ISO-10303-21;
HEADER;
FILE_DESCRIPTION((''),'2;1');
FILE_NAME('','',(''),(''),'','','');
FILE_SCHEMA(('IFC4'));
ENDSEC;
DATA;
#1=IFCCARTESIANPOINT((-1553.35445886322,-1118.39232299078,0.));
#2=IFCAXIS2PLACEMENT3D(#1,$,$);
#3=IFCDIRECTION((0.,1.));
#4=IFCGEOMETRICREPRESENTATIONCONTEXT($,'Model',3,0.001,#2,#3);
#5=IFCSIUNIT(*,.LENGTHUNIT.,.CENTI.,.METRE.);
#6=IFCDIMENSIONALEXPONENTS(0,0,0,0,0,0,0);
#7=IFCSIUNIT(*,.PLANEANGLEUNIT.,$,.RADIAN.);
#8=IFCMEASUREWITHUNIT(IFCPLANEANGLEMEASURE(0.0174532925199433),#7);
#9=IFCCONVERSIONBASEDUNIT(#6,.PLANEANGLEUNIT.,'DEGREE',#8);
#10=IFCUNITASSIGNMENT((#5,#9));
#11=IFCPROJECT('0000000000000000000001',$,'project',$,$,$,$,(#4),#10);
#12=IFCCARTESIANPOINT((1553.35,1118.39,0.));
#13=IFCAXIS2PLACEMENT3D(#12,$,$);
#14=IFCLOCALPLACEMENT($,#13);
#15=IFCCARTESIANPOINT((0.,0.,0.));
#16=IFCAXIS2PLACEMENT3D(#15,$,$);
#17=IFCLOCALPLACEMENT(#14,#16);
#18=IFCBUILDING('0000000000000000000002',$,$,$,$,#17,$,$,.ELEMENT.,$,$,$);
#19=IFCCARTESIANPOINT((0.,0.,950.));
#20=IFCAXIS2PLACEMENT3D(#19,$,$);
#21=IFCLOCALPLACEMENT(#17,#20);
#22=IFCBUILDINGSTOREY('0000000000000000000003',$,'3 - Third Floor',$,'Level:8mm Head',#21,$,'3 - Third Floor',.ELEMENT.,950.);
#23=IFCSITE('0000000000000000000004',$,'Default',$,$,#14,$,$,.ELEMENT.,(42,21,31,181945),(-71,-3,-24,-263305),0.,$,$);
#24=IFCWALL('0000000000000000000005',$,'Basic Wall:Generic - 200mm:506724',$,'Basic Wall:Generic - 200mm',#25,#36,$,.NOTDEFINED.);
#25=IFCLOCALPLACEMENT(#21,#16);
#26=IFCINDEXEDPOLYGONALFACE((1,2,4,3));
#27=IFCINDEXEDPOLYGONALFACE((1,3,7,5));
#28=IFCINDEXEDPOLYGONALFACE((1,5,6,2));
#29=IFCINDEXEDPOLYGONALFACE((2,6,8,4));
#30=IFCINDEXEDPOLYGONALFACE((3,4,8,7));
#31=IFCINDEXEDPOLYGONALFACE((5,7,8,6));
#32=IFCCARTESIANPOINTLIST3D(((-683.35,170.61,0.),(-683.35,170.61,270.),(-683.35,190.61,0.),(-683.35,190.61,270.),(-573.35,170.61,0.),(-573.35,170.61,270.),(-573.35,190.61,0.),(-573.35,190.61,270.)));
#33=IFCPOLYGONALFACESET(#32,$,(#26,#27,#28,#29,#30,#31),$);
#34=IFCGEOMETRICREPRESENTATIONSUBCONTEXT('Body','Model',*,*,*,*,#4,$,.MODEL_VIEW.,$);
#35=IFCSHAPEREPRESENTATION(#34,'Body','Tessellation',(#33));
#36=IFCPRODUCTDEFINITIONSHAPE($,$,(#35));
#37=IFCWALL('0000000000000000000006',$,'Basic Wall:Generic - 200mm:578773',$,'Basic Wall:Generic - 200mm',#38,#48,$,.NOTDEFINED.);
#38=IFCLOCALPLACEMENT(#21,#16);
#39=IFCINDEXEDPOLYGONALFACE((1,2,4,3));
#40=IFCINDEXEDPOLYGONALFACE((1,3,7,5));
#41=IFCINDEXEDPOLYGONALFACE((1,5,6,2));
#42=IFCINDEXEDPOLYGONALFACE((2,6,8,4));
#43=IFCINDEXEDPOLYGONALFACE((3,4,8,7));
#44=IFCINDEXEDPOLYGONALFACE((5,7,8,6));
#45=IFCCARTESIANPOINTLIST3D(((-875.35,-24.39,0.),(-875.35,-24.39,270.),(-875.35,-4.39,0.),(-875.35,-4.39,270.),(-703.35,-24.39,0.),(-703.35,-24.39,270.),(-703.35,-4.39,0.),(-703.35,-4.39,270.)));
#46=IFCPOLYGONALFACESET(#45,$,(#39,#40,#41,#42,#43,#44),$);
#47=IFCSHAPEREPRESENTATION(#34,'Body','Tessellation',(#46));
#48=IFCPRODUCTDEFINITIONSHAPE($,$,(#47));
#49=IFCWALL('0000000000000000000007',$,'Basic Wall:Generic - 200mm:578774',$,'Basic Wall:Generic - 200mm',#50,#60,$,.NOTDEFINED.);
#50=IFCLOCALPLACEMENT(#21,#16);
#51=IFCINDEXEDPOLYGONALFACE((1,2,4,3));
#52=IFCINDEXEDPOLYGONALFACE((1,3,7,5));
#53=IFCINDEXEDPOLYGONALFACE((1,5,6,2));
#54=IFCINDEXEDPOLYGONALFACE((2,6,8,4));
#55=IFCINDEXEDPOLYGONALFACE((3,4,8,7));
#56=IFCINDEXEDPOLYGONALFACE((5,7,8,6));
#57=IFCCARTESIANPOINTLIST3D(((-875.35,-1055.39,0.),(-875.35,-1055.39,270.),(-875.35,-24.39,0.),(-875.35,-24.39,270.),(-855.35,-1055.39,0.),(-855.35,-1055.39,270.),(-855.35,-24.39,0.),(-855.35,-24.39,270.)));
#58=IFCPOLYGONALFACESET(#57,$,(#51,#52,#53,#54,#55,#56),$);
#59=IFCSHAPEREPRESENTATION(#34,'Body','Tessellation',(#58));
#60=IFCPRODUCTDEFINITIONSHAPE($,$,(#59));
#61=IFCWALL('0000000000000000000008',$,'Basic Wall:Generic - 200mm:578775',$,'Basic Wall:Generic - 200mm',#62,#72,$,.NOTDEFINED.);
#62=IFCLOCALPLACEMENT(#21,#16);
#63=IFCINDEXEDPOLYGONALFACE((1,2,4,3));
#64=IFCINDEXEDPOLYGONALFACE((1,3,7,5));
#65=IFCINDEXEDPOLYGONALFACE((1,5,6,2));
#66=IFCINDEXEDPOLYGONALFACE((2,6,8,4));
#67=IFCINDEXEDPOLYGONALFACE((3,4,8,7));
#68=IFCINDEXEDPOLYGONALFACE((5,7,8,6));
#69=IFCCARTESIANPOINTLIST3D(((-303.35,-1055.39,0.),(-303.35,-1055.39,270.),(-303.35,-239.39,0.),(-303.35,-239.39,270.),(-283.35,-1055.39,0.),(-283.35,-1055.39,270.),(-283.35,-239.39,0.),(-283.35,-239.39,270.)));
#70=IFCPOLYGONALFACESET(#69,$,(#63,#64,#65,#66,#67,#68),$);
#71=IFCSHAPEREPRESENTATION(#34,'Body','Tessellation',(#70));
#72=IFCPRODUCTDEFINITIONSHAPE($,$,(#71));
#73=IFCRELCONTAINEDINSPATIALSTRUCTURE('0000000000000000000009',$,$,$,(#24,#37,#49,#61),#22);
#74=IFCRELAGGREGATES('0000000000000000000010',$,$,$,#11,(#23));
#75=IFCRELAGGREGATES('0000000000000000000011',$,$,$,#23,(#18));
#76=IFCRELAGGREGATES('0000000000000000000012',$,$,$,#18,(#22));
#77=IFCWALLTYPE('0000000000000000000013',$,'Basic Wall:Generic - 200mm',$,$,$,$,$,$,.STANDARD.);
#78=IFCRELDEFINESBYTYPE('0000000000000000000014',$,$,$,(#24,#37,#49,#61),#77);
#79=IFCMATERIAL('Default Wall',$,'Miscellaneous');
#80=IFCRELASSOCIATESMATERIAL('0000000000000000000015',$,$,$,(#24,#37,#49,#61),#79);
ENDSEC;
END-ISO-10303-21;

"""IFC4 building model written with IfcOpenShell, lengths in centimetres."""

from ifc_helpers import new_model, entity, si_unit, converted_unit, direction, frame, origin, place, context, subcontext, project, spatial, indexed_curve, outline, extrude, material, type_object, element, save


model = new_model("IFC4")

# Units and contexts
model_context = context("Model", 3, precision=0.001, world=frame((-1553.35445886322, -1118.39232299078, 0.0)), true_north=direction((0.0, 1.0)))
body_context = subcontext(model_context, "Body", "Model", "MODEL_VIEW")
ifc_project = project(units=[si_unit("LENGTHUNIT", "METRE", prefix="CENTI"), converted_unit("PLANEANGLEUNIT", "DEGREE", entity("IfcPlaneAngleMeasure", 0.0174532925199433), si_unit("PLANEANGLEUNIT", "RADIAN"), dimensions=[0, 0, 0, 0, 0, 0, 0])], contexts=[model_context])

# Site, building, storey
site_placement = place(None, frame((1553.35, 1118.39, 0.0)))
site = spatial("IfcSite", under=ifc_project, at=site_placement, Name="Default", CompositionType="ELEMENT", RefLatitude=(42, 21, 31, 181945), RefLongitude=(-71, -3, -24, -263305), RefElevation=0.0)
building_placement = place(site_placement, origin())
building = spatial("IfcBuilding", under=site, at=building_placement, CompositionType="ELEMENT")
storey_placement = place(building_placement, frame((0.0, 0.0, 950.0)))
storey = spatial("IfcBuildingStorey", under=building, at=storey_placement, Name="3 - Third Floor", ObjectType="Level:8mm Head", LongName="3 - Third Floor", CompositionType="ELEMENT", Elevation=950.0)

# Walls
ifc_material_1 = material(Name="Default Wall", Category="Miscellaneous")
wall_type_1 = type_object("IfcWallType", Name="Basic Wall:Generic - 200mm", PredefinedType="STANDARD")
wall_1_placement = place(storey_placement, frame((-683.35, 180.61, 0.0)))
element("IfcWall", 1, at=wall_1_placement, inside=storey, type_object=wall_type_1, material=ifc_material_1, Name="Basic Wall:Generic - 200mm:506724", ObjectType="Basic Wall:Generic - 200mm", PredefinedType="NOTDEFINED", context=body_context, shape_type="SweptSolid", body=[
    extrude(outline(indexed_curve([(110.0, 10.0), (0.0, 10.0), (0.0, -10.0), (110.0, -10.0), (110.0, 10.0)], self_intersect=False)), origin(), (0.0, 0.0, 1.0), 270.0),
])
wall_2_placement = place(storey_placement, frame((-703.35, -14.39, 0.0), z_axis=(0.0, 0.0, 1.0), x_axis=(-1.0, 0.0, 0.0)))
element("IfcWall", 2, at=wall_2_placement, inside=storey, type_object=wall_type_1, material=ifc_material_1, Name="Basic Wall:Generic - 200mm:578773", ObjectType="Basic Wall:Generic - 200mm", PredefinedType="NOTDEFINED", context=body_context, shape_type="SweptSolid", body=[
    extrude(outline(indexed_curve([(172.0, 10.0), (0.0, 10.0), (0.0, -10.0), (172.0, -10.0), (172.0, 10.0)], self_intersect=False)), origin(), (0.0, 0.0, 1.0), 270.0),
])
wall_3_placement = place(storey_placement, frame((-865.35, -24.39, 0.0), z_axis=(0.0, 0.0, 1.0), x_axis=(0.0, -1.0, 0.0)))
element("IfcWall", 3, at=wall_3_placement, inside=storey, type_object=wall_type_1, material=ifc_material_1, Name="Basic Wall:Generic - 200mm:578774", ObjectType="Basic Wall:Generic - 200mm", PredefinedType="NOTDEFINED", context=body_context, shape_type="SweptSolid", body=[
    extrude(outline(indexed_curve([(1031.0, 10.0), (0.0, 10.0), (0.0, -10.0), (1031.0, -10.0), (1031.0, 10.0)], self_intersect=False)), origin(), (0.0, 0.0, 1.0), 270.0),
])
wall_4_placement = place(storey_placement, frame((-293.35, -239.39, 0.0), z_axis=(0.0, 0.0, 1.0), x_axis=(0.0, -1.0, 0.0)))
element("IfcWall", 4, at=wall_4_placement, inside=storey, type_object=wall_type_1, material=ifc_material_1, Name="Basic Wall:Generic - 200mm:578775", ObjectType="Basic Wall:Generic - 200mm", PredefinedType="NOTDEFINED", context=body_context, shape_type="SweptSolid", body=[
    extrude(outline(indexed_curve([(816.0, 10.0), (0.0, 10.0), (0.0, -10.0), (816.0, -10.0), (816.0, 10.0)], self_intersect=False)), origin(), (0.0, 0.0, 1.0), 270.0),
])

save(model, "model.ifc")
